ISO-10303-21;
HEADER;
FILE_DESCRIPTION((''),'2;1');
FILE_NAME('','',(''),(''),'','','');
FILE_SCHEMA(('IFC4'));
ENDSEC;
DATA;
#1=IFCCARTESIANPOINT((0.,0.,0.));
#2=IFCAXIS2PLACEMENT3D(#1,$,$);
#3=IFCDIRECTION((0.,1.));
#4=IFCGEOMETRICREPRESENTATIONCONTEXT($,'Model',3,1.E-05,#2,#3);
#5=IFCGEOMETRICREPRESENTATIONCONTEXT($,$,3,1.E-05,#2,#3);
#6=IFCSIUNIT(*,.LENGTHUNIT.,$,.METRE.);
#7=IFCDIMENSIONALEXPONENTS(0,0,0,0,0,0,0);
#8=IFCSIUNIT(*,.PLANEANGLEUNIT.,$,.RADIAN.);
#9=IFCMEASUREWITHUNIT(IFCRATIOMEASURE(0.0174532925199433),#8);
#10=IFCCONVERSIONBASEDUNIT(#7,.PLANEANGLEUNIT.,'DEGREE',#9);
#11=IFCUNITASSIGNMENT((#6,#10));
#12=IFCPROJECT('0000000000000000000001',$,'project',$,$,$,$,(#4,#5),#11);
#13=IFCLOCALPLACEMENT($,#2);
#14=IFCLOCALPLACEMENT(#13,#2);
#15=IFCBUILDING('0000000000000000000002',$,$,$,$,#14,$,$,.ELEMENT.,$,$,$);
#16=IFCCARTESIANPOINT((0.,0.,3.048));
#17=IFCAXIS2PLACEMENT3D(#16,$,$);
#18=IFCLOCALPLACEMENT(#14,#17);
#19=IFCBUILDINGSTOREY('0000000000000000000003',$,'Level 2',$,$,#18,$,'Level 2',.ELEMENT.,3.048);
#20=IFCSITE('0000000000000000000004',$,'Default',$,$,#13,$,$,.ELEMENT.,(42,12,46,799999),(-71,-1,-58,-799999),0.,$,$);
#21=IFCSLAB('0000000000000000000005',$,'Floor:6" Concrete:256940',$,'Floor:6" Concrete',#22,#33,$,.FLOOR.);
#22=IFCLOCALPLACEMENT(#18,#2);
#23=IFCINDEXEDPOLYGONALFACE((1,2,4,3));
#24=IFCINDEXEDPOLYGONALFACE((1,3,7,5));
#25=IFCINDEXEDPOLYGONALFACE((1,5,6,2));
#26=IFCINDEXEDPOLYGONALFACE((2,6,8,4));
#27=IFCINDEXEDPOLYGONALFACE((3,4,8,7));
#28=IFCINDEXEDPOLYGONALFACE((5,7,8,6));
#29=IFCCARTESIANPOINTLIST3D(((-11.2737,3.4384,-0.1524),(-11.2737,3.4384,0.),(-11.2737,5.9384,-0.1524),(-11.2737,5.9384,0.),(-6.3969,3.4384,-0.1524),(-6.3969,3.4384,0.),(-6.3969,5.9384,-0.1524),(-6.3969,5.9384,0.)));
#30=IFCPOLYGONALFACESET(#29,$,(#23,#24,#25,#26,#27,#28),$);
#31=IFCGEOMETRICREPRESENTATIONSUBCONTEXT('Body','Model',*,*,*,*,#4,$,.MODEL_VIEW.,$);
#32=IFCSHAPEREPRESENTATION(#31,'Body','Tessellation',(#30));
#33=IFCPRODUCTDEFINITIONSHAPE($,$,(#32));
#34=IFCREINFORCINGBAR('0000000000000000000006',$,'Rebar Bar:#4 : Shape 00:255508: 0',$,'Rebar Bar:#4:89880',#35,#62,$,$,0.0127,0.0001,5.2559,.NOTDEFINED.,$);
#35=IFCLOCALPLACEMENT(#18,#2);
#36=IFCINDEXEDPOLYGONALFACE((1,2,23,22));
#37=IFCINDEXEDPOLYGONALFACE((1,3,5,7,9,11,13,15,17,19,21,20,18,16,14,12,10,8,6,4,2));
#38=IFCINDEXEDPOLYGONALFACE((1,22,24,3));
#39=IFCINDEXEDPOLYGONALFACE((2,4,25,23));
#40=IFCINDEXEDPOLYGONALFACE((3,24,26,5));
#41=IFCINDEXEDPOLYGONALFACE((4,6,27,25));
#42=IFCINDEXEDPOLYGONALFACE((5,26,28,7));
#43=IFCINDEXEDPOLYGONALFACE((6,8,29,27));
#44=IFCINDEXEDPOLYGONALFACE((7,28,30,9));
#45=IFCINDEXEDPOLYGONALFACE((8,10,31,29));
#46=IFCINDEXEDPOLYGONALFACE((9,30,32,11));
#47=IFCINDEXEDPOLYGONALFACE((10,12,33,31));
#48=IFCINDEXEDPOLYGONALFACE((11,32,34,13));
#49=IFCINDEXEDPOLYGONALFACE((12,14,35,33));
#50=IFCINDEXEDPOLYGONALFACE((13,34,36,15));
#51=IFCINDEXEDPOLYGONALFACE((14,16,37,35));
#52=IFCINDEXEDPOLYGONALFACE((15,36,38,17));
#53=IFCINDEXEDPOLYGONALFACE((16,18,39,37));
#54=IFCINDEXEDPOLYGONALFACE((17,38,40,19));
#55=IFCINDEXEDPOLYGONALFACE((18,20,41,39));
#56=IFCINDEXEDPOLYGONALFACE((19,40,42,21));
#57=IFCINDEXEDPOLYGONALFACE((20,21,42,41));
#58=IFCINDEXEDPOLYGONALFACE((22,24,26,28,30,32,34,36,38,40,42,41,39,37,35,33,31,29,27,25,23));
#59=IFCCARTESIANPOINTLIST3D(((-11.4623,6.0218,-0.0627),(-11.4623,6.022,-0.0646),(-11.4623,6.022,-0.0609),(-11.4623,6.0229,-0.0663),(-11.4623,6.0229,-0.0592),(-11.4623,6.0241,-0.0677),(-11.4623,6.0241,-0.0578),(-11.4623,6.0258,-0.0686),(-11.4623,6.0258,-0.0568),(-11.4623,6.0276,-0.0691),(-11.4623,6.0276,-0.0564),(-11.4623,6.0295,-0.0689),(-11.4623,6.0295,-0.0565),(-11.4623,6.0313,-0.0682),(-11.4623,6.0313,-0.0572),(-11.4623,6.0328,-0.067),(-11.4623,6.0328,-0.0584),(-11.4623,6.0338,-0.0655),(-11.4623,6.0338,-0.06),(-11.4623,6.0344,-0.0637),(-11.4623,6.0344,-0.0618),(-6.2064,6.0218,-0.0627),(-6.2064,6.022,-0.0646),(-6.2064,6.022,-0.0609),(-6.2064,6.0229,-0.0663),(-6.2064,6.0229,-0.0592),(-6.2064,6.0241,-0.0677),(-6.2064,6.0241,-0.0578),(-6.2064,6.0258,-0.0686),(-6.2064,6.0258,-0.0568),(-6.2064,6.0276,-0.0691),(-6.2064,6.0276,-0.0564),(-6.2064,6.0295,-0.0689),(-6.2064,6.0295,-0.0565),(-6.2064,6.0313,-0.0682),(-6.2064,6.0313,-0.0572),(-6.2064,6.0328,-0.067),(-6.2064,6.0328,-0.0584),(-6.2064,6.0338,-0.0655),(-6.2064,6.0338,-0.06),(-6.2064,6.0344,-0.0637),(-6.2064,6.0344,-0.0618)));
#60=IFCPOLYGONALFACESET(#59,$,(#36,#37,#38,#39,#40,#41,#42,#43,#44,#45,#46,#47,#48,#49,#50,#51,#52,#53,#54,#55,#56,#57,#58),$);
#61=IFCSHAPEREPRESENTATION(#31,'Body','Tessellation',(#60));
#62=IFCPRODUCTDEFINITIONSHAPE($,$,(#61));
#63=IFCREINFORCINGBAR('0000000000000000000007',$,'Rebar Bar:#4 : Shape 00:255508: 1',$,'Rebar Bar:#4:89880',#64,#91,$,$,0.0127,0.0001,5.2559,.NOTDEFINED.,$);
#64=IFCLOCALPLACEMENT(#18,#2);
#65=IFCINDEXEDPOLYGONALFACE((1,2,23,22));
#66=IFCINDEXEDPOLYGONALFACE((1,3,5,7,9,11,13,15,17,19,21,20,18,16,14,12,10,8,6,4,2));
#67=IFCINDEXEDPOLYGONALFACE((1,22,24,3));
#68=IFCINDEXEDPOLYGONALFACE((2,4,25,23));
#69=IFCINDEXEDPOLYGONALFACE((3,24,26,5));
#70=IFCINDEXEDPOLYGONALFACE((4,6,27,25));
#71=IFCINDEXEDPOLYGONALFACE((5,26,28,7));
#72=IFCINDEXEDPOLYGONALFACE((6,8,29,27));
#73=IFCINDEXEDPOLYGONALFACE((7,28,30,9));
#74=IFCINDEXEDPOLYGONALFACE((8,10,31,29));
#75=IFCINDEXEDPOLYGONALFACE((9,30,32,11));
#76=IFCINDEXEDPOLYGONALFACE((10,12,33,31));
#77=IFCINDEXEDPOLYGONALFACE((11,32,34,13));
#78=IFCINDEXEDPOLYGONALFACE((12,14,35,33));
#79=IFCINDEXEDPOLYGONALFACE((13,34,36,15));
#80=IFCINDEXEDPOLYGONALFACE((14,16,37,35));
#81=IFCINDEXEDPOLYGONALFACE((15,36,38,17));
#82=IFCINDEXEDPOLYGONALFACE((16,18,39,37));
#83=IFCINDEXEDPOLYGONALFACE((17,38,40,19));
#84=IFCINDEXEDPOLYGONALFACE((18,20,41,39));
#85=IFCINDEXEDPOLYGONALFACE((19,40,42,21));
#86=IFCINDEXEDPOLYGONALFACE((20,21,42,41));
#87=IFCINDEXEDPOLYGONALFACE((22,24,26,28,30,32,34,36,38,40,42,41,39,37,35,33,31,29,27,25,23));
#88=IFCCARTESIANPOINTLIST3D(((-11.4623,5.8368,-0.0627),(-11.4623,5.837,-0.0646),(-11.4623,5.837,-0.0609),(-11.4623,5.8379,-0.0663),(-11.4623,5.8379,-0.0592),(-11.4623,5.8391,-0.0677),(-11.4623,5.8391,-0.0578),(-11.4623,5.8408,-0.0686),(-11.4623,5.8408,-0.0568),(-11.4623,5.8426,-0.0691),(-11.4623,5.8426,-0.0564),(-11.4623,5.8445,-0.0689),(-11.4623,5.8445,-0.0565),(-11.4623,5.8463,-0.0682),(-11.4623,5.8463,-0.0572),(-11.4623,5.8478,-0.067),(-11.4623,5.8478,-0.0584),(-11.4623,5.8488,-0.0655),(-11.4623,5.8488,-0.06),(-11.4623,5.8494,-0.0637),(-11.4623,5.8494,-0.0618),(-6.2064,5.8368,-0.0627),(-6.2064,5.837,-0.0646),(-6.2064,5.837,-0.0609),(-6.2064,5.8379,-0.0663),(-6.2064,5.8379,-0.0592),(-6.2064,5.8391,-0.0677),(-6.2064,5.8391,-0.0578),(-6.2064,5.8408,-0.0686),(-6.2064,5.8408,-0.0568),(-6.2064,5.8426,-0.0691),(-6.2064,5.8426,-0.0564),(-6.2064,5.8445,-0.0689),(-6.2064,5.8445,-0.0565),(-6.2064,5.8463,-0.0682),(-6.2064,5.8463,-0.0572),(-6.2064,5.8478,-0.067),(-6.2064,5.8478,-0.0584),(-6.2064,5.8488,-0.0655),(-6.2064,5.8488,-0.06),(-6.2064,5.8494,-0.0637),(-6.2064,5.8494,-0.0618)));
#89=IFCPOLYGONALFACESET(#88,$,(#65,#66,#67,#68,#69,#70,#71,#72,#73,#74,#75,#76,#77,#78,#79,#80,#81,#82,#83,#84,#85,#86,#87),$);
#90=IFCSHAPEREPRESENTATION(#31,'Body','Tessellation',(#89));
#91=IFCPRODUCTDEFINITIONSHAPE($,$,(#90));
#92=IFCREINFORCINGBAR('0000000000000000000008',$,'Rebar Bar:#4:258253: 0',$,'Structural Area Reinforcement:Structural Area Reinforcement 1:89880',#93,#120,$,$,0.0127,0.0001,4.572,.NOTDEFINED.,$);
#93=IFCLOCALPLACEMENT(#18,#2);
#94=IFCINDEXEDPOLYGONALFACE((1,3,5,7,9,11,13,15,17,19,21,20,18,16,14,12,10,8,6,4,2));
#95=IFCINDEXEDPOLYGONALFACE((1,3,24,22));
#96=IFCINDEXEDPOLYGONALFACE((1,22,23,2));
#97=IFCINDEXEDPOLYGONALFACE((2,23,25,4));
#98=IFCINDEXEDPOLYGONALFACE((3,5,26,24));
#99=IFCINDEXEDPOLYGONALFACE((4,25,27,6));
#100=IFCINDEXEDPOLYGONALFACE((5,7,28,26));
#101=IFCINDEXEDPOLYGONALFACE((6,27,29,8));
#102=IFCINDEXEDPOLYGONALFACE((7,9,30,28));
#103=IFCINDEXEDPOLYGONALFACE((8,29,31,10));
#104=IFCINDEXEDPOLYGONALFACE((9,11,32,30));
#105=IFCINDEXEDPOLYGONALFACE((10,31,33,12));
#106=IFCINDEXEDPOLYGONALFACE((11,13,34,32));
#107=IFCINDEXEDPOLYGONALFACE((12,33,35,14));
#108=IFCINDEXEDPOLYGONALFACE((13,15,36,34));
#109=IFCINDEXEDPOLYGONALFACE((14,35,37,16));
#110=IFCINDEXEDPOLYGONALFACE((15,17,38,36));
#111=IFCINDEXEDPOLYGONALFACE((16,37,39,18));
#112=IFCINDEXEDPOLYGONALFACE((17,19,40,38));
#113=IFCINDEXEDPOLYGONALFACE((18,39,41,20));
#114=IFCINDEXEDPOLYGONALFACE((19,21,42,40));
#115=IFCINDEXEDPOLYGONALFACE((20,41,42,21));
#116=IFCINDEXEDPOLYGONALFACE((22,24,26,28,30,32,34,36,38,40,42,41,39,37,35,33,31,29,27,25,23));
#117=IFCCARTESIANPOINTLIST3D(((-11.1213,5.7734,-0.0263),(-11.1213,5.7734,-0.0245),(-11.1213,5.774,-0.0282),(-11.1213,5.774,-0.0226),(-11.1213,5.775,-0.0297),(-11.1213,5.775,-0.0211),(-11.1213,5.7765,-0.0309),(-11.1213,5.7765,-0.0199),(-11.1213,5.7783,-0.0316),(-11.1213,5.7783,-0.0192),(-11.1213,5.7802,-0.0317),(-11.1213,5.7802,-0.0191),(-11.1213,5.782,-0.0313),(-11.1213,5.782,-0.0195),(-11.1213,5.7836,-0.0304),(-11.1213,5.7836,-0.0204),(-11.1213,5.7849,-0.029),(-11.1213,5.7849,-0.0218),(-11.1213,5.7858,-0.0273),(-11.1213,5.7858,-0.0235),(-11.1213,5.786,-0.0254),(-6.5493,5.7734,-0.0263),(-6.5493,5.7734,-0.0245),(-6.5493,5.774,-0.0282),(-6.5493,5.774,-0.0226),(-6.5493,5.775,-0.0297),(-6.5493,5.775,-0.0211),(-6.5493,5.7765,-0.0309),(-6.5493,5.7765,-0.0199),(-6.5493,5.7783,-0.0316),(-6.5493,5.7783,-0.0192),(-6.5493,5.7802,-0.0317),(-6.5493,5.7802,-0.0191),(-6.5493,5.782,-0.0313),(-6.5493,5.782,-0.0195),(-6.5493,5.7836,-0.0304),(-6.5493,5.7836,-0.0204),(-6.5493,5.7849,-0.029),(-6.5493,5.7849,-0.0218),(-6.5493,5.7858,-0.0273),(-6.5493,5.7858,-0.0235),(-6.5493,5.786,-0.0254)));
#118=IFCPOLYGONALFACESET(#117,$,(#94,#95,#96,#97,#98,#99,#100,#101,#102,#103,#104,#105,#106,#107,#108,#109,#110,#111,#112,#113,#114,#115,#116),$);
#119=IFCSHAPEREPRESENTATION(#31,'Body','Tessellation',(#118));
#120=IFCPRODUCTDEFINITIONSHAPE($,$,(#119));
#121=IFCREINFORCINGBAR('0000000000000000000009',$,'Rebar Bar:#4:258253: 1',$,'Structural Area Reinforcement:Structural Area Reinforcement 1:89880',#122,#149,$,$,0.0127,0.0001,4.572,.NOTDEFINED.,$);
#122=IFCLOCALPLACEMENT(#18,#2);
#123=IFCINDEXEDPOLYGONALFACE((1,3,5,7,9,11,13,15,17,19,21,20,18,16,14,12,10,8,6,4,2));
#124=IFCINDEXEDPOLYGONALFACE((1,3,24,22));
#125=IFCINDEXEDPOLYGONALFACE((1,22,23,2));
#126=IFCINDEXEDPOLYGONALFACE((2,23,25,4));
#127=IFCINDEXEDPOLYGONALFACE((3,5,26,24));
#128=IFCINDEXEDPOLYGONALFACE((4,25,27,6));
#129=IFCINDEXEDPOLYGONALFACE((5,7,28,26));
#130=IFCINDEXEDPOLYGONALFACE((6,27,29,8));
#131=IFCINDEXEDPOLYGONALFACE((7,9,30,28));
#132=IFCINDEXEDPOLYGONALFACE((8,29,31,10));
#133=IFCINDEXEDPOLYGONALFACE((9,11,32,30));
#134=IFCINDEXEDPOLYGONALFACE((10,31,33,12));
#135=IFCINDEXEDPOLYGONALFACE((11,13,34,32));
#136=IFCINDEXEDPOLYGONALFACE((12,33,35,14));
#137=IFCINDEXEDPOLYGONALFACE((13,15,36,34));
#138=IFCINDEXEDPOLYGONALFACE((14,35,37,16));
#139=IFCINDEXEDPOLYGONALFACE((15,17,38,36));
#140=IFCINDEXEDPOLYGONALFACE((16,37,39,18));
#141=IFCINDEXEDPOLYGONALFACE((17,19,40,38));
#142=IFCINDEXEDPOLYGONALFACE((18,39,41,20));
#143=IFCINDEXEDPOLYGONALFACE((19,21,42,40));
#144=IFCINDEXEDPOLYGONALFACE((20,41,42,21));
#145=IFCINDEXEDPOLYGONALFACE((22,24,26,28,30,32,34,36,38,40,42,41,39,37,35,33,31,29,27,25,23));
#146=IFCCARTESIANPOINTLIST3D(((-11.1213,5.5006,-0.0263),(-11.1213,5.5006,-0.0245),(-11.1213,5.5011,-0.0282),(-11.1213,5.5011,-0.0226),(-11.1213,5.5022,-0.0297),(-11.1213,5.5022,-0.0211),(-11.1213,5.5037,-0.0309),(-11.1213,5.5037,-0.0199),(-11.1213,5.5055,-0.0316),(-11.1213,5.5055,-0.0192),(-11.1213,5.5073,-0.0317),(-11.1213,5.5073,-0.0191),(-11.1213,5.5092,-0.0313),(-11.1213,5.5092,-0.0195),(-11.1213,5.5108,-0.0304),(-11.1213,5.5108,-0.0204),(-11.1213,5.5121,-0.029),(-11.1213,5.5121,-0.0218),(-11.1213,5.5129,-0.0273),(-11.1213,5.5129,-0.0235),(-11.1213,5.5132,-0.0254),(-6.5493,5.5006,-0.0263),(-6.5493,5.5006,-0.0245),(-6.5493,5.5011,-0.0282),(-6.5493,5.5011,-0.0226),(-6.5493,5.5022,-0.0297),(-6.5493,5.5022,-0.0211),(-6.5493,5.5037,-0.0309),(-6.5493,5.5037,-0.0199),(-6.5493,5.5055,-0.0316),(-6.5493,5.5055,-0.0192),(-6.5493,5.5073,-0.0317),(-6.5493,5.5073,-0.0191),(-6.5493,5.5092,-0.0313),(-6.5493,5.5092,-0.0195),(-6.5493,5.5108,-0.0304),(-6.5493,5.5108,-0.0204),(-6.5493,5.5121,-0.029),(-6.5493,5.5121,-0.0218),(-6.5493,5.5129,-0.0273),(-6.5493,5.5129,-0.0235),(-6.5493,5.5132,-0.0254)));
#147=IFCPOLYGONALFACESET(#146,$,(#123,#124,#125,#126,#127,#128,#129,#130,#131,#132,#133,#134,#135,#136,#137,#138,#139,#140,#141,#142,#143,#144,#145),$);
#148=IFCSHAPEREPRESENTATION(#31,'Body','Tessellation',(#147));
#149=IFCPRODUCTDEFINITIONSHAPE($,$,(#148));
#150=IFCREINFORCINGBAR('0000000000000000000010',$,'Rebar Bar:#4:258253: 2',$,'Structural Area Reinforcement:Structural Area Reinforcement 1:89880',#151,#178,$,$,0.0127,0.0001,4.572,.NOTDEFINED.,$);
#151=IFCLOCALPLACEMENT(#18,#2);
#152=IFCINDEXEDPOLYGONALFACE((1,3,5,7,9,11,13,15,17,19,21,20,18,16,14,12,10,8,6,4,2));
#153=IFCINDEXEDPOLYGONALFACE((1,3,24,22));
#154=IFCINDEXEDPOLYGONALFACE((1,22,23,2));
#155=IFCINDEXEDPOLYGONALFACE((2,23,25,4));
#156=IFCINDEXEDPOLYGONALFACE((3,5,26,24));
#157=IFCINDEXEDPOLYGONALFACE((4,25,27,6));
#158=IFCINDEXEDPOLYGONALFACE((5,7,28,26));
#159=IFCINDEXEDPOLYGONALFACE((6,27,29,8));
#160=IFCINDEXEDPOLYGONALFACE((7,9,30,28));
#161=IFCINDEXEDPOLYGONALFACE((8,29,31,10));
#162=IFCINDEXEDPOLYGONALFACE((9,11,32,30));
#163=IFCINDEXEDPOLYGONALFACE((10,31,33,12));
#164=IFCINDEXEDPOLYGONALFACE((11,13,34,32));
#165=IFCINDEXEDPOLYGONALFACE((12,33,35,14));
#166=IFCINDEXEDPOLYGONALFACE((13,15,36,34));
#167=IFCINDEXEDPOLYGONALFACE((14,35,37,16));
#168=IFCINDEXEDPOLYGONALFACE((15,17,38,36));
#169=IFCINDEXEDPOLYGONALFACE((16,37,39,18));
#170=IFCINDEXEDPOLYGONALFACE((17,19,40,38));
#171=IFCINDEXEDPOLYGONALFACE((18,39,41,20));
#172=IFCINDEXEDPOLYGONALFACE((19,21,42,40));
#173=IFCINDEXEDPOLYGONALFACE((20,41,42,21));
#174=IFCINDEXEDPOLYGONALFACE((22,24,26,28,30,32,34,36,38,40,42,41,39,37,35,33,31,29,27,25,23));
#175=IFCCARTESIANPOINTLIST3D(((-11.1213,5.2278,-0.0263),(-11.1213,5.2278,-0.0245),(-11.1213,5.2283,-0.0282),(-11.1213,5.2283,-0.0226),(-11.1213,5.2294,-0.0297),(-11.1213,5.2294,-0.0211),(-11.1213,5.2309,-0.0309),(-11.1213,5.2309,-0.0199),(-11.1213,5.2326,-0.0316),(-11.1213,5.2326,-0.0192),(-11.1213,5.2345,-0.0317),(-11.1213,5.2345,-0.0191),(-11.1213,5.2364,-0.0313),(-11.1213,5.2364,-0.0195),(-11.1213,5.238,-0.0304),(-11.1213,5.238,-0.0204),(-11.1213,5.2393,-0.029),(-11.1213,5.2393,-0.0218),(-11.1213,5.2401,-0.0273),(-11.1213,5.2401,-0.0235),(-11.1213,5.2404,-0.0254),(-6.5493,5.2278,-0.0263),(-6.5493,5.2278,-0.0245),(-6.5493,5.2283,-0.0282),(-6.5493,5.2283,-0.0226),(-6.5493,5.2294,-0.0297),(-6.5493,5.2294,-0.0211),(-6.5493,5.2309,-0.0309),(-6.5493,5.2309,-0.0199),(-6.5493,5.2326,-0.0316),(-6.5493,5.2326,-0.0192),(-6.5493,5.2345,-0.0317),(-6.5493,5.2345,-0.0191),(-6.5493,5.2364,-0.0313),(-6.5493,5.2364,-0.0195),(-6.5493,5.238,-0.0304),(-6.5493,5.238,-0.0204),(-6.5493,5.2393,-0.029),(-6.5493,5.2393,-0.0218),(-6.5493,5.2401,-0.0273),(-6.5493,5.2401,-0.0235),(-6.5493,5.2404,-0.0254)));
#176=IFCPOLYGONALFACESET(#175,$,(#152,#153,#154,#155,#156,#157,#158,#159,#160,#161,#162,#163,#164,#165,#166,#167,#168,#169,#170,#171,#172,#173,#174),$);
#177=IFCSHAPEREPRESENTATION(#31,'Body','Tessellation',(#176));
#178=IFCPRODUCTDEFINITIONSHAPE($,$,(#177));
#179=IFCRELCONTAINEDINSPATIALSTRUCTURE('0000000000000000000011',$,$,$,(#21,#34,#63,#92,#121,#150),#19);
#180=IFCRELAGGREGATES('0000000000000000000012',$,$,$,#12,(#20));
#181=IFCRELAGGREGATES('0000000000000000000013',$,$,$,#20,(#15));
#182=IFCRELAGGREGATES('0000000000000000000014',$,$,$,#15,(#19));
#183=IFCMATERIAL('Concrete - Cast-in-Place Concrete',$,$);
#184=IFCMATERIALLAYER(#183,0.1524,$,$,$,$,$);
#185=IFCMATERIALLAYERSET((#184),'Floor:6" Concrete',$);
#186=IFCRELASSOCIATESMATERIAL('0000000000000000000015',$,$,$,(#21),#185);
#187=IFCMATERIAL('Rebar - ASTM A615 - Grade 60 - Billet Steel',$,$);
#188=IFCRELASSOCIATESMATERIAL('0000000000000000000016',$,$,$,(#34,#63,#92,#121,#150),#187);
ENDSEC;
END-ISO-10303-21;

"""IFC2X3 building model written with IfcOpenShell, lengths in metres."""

from ifc_helpers import new_model, entity, si_unit, converted_unit, direction, frame, frame_2d, origin, place, context, subcontext, project, spatial, rectangle, extrude, material, layer, layer_set, layer_usage, element, save


model = new_model("IFC2X3")

# Units and contexts
model_context = context("Model", 3, precision=1e-05, world=origin(), true_north=direction((0.0, 1.0)))
context_of_model = context(None, 3, precision=1e-05, world=origin(), true_north=direction((0.0, 1.0)))
body_context = subcontext(model_context, "Body", "Model", "MODEL_VIEW")
ifc_project = project(units=[si_unit("LENGTHUNIT", "METRE"), converted_unit("PLANEANGLEUNIT", "DEGREE", entity("IfcRatioMeasure", 0.0174532925199433), si_unit("PLANEANGLEUNIT", "RADIAN"), dimensions=[0, 0, 0, 0, 0, 0, 0])], contexts=[model_context, context_of_model])

# Site, building, storey
site_placement = place(None, origin())
site = spatial("IfcSite", under=ifc_project, at=site_placement, Name="Default", CompositionType="ELEMENT", RefLatitude=(42, 12, 46, 799999), RefLongitude=(-71, -1, -58, -799999), RefElevation=0.0)
building_placement = place(site_placement, origin())
building = spatial("IfcBuilding", under=site, at=building_placement, CompositionType="ELEMENT")
storey_placement = place(building_placement, frame((0.0, 0.0, 3.048)))
storey = spatial("IfcBuildingStorey", under=building, at=storey_placement, Name="Level 2", LongName="Level 2", CompositionType="ELEMENT", Elevation=3.048)

# Shared definitions
ifc_material_1 = material(Name="Concrete - Cast-in-Place Concrete")

# Slab
ifc_layer = layer(ifc_material_1, 0.1524)
ifc_layer_set = layer_set([ifc_layer], Name="Floor:6\" Concrete")
ifc_layer_usage = layer_usage(ifc_layer_set, "AXIS3", "POSITIVE", 0.0)
slab_placement = place(storey_placement, origin())
element("IfcSlab", 1, at=slab_placement, inside=storey, material=ifc_layer_usage, Name="Floor:6\" Concrete:256940", ObjectType="Floor:6\" Concrete", PredefinedType="FLOOR", context=body_context, shape_type="SweptSolid", body=[
    extrude(rectangle(XDim=2.5, YDim=4.8768, at=frame_2d((0.0, 0.0), x_axis=(1.0, 0.0))), frame((-8.8353, 4.6884, 0.0), z_axis=(0.0, 0.0, -1.0), x_axis=(0.0, 1.0, 0.0)), (0.0, 0.0, 1.0), 0.1524),
])

# Reinforcing bars
ifc_material_2 = material(Name="Rebar - ASTM A615 - Grade 60 - Billet Steel")
reinforcing_bar_1_placement = place(storey_placement, origin())
element("IfcReinforcingBar", 2, at=reinforcing_bar_1_placement, inside=storey, material=ifc_material_2, Name="Rebar Bar:#4 : Shape 00:255508: 0", ObjectType="Rebar Bar:#4:89880", BarLength=5.2559, BarRole="NOTDEFINED", CrossSectionArea=0.0001, NominalDiameter=0.0127, context=body_context, shape_type="AdvancedSweptSolid", body=[
    entity("IfcSweptDiskSolid", entity("IfcCompositeCurve", [entity("IfcCompositeCurveSegment", "CONTINUOUS", True, entity("IfcPolyline", [entity("IfcCartesianPoint", [-6.2064, 6.0281, -0.0627]), entity("IfcCartesianPoint", [-11.4623, 6.0281, -0.0627])]))], False), 0.0063, None, 0.0, 1.0),
])
reinforcing_bar_2_placement = place(storey_placement, origin())
element("IfcReinforcingBar", 3, at=reinforcing_bar_2_placement, inside=storey, material=ifc_material_2, Name="Rebar Bar:#4 : Shape 00:255508: 1", ObjectType="Rebar Bar:#4:89880", BarLength=5.2559, BarRole="NOTDEFINED", CrossSectionArea=0.0001, NominalDiameter=0.0127, context=body_context, shape_type="AdvancedSweptSolid", body=[
    entity("IfcSweptDiskSolid", entity("IfcCompositeCurve", [entity("IfcCompositeCurveSegment", "CONTINUOUS", True, entity("IfcPolyline", [entity("IfcCartesianPoint", [-6.2064, 5.8431, -0.0627]), entity("IfcCartesianPoint", [-11.4623, 5.8431, -0.0627])]))], False), 0.0063, None, 0.0, 1.0),
])
reinforcing_bar_3_placement = place(storey_placement, origin())
element("IfcReinforcingBar", 4, at=reinforcing_bar_3_placement, inside=storey, material=ifc_material_2, Name="Rebar Bar:#4:258253: 0", ObjectType="Structural Area Reinforcement:Structural Area Reinforcement 1:89880", BarLength=4.572, BarRole="NOTDEFINED", CrossSectionArea=0.0001, NominalDiameter=0.0127, context=body_context, shape_type="AdvancedSweptSolid", body=[
    entity("IfcSweptDiskSolid", entity("IfcCompositeCurve", [entity("IfcCompositeCurveSegment", "CONTINUOUS", True, entity("IfcPolyline", [entity("IfcCartesianPoint", [-11.1213, 5.7797, -0.0254]), entity("IfcCartesianPoint", [-6.5493, 5.7797, -0.0254])]))], False), 0.0063, None, 0.0, 1.0),
])
reinforcing_bar_4_placement = place(storey_placement, origin())
element("IfcReinforcingBar", 5, at=reinforcing_bar_4_placement, inside=storey, material=ifc_material_2, Name="Rebar Bar:#4:258253: 1", ObjectType="Structural Area Reinforcement:Structural Area Reinforcement 1:89880", BarLength=4.572, BarRole="NOTDEFINED", CrossSectionArea=0.0001, NominalDiameter=0.0127, context=body_context, shape_type="AdvancedSweptSolid", body=[
    entity("IfcSweptDiskSolid", entity("IfcCompositeCurve", [entity("IfcCompositeCurveSegment", "CONTINUOUS", True, entity("IfcPolyline", [entity("IfcCartesianPoint", [-11.1213, 5.5069, -0.0254]), entity("IfcCartesianPoint", [-6.5493, 5.5069, -0.0254])]))], False), 0.0063, None, 0.0, 1.0),
])
reinforcing_bar_5_placement = place(storey_placement, origin())
element("IfcReinforcingBar", 6, at=reinforcing_bar_5_placement, inside=storey, material=ifc_material_2, Name="Rebar Bar:#4:258253: 2", ObjectType="Structural Area Reinforcement:Structural Area Reinforcement 1:89880", BarLength=4.572, BarRole="NOTDEFINED", CrossSectionArea=0.0001, NominalDiameter=0.0127, context=body_context, shape_type="AdvancedSweptSolid", body=[
    entity("IfcSweptDiskSolid", entity("IfcCompositeCurve", [entity("IfcCompositeCurveSegment", "CONTINUOUS", True, entity("IfcPolyline", [entity("IfcCartesianPoint", [-11.1213, 5.2341, -0.0254]), entity("IfcCartesianPoint", [-6.5493, 5.2341, -0.0254])]))], False), 0.0063, None, 0.0, 1.0),
])

save(model, "model.ifc")
